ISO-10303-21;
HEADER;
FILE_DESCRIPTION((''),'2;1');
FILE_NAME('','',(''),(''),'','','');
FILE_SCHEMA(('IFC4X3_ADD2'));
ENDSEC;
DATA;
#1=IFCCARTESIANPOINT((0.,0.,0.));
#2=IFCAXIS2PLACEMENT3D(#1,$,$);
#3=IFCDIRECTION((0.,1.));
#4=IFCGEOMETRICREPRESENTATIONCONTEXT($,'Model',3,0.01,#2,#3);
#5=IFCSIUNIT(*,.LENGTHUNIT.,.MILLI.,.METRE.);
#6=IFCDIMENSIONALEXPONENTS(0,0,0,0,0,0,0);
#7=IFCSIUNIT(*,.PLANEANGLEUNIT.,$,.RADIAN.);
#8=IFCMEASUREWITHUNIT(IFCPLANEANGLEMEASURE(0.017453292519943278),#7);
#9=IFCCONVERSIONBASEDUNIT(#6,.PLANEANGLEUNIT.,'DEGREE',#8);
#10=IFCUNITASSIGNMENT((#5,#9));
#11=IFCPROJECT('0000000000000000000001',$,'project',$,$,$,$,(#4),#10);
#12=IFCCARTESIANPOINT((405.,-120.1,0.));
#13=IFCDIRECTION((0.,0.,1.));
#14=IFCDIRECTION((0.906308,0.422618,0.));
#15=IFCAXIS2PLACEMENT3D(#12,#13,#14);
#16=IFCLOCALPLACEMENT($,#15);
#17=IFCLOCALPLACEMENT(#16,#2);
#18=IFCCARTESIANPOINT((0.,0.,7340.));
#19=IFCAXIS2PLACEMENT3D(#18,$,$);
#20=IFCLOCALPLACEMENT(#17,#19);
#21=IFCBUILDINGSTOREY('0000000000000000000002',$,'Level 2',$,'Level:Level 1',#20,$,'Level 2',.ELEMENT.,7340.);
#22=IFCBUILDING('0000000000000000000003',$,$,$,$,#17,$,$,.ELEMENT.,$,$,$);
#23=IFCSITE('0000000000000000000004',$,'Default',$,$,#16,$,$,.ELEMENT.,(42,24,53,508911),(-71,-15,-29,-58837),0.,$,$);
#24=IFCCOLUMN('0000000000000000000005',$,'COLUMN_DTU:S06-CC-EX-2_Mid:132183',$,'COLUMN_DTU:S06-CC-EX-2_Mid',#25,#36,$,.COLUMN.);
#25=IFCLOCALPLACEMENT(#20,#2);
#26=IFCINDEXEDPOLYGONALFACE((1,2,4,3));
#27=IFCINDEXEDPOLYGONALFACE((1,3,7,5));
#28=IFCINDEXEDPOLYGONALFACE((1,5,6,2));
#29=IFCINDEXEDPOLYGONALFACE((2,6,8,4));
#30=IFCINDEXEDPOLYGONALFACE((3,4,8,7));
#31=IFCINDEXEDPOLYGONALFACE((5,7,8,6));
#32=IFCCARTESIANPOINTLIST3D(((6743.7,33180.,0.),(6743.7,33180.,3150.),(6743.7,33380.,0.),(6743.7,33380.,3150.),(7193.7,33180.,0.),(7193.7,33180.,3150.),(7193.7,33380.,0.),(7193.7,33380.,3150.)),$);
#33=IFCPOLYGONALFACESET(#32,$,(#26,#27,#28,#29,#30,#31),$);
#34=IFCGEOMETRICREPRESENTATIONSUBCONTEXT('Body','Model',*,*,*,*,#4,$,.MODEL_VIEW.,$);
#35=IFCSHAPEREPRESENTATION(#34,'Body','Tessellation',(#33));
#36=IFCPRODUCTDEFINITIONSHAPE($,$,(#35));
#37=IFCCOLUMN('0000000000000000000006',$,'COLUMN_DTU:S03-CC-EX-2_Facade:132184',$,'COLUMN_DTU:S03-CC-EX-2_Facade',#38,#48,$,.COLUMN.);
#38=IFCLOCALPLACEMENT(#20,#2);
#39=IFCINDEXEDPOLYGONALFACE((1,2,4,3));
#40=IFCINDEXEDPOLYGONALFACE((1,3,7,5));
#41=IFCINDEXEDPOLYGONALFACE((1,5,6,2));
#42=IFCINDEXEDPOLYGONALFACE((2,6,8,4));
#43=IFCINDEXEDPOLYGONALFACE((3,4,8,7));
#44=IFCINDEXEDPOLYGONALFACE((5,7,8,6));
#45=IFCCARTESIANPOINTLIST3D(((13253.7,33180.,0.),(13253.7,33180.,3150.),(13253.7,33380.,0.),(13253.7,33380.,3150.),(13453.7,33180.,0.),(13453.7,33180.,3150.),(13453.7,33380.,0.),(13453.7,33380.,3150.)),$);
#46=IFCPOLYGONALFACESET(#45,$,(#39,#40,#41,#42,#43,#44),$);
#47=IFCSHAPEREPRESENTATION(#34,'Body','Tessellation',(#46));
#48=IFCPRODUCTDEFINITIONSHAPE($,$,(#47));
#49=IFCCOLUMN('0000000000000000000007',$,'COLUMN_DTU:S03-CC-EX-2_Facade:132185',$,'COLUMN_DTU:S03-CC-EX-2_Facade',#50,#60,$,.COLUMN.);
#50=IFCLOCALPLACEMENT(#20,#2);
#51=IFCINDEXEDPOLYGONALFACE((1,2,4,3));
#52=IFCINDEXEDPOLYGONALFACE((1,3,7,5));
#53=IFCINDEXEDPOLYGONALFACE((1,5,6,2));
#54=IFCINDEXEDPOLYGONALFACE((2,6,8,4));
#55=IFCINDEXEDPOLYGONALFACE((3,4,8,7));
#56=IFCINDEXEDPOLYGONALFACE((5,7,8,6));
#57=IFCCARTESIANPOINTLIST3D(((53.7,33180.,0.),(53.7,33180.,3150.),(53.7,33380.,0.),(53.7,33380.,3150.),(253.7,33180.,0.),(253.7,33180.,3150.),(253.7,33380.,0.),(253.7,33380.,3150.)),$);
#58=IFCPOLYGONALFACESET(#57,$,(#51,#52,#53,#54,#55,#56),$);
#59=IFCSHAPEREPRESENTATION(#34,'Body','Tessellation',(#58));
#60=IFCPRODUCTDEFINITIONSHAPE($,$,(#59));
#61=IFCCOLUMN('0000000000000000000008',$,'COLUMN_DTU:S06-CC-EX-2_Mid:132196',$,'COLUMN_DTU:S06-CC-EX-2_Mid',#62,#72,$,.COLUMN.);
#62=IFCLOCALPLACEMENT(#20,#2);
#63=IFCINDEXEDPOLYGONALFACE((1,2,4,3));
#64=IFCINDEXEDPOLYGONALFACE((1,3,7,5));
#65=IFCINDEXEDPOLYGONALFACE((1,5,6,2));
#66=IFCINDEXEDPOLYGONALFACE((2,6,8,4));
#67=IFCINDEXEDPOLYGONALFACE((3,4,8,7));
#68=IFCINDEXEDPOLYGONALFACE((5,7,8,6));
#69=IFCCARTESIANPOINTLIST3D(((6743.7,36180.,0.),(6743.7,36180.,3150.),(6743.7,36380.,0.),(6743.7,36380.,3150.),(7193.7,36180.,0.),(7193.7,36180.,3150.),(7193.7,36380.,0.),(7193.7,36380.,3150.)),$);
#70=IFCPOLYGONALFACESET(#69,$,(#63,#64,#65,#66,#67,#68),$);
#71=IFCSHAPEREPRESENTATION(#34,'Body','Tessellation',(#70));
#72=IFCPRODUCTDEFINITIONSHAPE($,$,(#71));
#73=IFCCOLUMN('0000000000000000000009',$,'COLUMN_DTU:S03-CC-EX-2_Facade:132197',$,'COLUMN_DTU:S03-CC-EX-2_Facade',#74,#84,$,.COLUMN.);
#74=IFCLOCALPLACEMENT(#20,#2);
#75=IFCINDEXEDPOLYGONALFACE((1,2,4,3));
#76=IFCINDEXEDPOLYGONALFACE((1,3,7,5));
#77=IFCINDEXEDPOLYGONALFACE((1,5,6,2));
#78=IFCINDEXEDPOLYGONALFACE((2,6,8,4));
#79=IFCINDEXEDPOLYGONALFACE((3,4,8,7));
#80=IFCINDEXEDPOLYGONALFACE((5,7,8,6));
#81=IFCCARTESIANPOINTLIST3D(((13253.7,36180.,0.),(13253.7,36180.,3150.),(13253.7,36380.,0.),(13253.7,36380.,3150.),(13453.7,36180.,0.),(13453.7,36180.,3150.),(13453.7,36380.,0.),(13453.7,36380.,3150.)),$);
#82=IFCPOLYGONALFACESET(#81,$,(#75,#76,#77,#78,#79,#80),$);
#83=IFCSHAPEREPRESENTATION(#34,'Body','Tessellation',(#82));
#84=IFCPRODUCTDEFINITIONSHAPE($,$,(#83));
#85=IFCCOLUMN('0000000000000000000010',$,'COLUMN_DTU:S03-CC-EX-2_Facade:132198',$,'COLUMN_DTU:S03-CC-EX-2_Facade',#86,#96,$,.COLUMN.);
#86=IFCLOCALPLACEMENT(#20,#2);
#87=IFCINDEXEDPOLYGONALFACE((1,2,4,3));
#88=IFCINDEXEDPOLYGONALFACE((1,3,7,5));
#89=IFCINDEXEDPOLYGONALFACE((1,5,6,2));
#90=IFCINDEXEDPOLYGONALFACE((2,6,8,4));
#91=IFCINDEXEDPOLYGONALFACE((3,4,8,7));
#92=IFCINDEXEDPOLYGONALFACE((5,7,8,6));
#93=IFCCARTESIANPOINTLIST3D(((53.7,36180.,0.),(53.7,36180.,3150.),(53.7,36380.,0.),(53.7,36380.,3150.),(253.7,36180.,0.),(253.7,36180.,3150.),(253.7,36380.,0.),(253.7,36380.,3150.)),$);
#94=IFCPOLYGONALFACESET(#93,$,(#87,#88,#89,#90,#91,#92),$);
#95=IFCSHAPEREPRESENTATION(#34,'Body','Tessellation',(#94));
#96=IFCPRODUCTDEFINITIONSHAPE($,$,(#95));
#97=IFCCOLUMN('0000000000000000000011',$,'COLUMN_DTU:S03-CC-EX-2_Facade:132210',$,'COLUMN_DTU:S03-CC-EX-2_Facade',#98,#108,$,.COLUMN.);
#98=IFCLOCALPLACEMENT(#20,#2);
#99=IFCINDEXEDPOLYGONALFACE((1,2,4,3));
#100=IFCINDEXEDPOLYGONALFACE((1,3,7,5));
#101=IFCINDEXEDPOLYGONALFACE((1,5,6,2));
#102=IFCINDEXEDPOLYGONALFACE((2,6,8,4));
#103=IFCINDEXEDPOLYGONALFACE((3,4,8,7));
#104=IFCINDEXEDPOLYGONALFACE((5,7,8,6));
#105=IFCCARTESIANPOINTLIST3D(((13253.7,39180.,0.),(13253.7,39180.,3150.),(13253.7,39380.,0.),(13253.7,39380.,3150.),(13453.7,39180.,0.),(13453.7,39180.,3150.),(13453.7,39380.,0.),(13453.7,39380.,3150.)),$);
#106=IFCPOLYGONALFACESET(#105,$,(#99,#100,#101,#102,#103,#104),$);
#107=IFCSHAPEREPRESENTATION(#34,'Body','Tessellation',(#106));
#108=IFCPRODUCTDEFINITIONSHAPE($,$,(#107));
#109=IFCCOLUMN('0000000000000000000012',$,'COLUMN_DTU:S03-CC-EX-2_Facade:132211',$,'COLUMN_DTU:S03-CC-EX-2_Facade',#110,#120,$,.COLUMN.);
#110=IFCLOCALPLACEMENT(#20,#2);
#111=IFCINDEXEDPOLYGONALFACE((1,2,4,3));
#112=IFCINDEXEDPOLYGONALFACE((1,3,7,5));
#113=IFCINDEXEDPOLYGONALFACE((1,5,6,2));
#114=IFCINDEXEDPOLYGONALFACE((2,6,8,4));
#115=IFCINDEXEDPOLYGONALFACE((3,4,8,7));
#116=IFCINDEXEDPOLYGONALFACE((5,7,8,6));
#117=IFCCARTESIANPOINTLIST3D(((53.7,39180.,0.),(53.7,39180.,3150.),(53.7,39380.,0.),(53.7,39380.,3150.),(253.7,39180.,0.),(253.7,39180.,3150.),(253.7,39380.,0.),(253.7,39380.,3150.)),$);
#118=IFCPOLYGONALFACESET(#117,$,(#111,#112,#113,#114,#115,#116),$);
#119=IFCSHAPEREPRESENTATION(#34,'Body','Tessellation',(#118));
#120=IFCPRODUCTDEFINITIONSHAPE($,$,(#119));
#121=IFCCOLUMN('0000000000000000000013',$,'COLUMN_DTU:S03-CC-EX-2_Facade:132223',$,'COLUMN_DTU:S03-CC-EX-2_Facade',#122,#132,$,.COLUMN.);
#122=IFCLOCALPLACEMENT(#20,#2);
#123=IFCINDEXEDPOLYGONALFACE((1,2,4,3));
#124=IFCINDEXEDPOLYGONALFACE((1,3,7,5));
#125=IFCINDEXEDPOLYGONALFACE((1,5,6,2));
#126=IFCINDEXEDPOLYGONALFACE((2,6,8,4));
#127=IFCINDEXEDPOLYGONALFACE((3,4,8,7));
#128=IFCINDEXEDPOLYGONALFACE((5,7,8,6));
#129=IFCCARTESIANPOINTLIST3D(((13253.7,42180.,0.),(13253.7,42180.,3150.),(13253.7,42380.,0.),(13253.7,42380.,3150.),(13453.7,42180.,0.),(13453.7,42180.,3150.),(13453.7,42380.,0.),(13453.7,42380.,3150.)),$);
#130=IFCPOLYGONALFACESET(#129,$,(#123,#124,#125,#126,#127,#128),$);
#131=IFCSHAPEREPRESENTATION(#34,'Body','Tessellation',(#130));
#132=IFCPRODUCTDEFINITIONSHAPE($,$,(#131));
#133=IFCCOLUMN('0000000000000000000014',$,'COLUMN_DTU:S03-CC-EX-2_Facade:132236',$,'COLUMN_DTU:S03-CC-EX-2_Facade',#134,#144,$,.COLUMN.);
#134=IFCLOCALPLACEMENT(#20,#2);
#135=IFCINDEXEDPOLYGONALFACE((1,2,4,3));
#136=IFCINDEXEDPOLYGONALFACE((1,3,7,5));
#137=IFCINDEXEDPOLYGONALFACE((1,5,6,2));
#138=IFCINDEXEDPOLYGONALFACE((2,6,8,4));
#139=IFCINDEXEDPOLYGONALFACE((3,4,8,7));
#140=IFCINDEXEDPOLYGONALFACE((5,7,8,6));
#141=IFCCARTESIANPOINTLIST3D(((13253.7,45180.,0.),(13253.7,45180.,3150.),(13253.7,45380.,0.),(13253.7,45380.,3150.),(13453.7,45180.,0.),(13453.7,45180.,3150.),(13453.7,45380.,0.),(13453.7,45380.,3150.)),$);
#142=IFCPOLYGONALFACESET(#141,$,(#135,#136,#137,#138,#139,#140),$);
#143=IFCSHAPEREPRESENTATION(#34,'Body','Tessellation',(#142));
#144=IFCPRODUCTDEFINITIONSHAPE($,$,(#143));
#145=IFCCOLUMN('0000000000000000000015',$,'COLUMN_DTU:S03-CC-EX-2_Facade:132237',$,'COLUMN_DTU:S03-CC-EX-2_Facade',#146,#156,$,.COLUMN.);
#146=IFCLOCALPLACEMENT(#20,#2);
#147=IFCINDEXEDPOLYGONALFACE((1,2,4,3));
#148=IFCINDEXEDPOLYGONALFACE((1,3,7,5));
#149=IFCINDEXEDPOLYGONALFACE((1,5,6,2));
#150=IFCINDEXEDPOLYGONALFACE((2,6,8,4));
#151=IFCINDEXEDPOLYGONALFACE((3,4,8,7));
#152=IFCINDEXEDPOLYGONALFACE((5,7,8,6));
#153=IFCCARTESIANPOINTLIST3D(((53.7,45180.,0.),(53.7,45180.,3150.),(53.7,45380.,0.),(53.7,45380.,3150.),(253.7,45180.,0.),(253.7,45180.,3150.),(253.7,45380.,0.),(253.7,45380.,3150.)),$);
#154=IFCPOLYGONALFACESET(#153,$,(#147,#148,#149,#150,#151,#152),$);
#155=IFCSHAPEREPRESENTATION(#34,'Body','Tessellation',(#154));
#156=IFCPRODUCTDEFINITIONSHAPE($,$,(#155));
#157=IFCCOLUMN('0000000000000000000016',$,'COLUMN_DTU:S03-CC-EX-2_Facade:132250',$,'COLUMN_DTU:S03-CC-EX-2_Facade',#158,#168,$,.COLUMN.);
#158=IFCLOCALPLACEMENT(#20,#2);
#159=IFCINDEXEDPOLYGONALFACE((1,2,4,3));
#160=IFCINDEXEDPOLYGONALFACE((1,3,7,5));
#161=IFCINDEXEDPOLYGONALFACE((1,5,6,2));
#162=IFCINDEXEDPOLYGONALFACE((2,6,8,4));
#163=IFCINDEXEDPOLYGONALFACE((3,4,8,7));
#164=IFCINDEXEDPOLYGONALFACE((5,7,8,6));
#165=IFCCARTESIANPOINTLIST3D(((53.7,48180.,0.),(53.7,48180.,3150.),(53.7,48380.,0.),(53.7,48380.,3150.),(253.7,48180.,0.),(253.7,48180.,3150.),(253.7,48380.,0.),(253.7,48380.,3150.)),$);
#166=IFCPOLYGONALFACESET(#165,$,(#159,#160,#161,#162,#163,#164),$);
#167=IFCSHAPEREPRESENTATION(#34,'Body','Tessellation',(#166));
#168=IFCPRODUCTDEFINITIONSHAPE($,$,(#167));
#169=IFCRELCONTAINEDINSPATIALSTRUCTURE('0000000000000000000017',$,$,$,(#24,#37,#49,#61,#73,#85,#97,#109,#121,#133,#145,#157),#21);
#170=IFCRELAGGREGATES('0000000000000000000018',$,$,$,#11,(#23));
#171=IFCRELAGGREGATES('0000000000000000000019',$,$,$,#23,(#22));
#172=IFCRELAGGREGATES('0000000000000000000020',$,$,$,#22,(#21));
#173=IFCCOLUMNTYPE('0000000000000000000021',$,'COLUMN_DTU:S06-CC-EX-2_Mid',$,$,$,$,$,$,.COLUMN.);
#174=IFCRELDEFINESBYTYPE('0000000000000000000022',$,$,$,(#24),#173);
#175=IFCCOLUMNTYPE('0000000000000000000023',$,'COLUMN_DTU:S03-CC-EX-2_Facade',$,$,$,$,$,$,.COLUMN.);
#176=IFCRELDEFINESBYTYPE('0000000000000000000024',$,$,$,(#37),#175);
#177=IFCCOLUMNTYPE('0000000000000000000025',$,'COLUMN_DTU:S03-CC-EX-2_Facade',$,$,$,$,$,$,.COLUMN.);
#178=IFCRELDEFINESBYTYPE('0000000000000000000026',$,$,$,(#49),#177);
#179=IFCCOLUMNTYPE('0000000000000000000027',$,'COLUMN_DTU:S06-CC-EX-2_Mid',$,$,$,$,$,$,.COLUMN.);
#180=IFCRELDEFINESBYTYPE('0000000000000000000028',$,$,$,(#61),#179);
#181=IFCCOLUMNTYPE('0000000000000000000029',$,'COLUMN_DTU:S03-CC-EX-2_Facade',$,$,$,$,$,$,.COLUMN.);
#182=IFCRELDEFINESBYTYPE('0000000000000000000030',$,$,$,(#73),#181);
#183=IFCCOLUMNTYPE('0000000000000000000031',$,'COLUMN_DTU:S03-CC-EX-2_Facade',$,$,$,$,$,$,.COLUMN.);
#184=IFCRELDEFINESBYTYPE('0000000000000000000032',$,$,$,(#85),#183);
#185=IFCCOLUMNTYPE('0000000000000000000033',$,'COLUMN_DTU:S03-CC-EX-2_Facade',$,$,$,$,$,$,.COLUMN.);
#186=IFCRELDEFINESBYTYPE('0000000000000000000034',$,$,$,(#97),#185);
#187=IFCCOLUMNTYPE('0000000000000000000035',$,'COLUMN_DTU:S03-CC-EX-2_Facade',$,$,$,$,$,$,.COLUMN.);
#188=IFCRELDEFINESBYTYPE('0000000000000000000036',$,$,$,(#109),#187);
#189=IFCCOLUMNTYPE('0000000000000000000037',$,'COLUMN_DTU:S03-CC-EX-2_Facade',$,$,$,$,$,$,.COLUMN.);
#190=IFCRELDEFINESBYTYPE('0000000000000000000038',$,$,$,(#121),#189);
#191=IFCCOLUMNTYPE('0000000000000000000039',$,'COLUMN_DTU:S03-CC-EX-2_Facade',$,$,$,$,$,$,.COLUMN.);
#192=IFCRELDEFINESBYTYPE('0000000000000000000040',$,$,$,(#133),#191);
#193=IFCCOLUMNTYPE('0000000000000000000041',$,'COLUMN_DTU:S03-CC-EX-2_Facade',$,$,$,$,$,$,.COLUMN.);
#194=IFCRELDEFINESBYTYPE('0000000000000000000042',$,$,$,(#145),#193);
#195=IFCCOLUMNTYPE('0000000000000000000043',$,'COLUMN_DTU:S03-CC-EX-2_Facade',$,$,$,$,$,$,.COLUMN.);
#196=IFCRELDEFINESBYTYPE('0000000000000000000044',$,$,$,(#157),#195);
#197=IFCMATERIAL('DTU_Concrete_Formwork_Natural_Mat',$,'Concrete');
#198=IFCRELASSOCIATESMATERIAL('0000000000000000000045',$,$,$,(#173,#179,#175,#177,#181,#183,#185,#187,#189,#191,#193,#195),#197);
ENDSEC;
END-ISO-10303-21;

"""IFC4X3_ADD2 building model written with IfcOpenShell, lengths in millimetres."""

from ifc_helpers import new_model, entity, si_unit, converted_unit, direction, frame, frame_2d, origin, origin_2d_with_axis, place, context, subcontext, project, spatial, rectangle, extrude, source, transform, mapped, material, material_profile, profile_set, type_object, type_shapes, element, save


model = new_model("IFC4X3_ADD2")

# Units and contexts
model_context = context("Model", 3, precision=0.01, world=origin(), true_north=direction((0.0, 1.0)))
body_context = subcontext(model_context, "Body", "Model", "MODEL_VIEW")
ifc_project = project(units=[si_unit("LENGTHUNIT", "METRE", prefix="MILLI"), converted_unit("PLANEANGLEUNIT", "DEGREE", entity("IfcPlaneAngleMeasure", 0.017453292519943278), si_unit("PLANEANGLEUNIT", "RADIAN"), dimensions=[0, 0, 0, 0, 0, 0, 0])], contexts=[model_context])

# Site, building, storey
site_placement = place(None, frame((405.0, -120.1, 0.0), z_axis=(0.0, 0.0, 1.0), x_axis=(0.906308, 0.422618, 0.0)))
site = spatial("IfcSite", under=ifc_project, at=site_placement, Name="Default", CompositionType="ELEMENT", RefLatitude=(42, 24, 53, 508911), RefLongitude=(-71, -15, -29, -58837), RefElevation=0.0)
building_placement = place(site_placement, origin())
building = spatial("IfcBuilding", under=site, at=building_placement, CompositionType="ELEMENT")
storey_placement = place(building_placement, frame((0.0, 0.0, 7340.0)))
storey = spatial("IfcBuildingStorey", under=building, at=storey_placement, Name="Level 2", ObjectType="Level:Level 1", LongName="Level 2", CompositionType="ELEMENT", Elevation=7340.0)

# Columns
ifc_material = material(Name="DTU_Concrete_Formwork_Natural_Mat", Category="Concrete")
ifc_material_profile_1 = material_profile(ifc_material, rectangle(XDim=200.0, YDim=450.0, at=origin_2d_with_axis()), Name="S06-CC-EX-2_Mid")
ifc_profile_set_1 = profile_set([ifc_material_profile_1], Name="S06-CC-EX-2_Mid")
column_type_1 = type_object("IfcColumnType", Name="COLUMN_DTU:S06-CC-EX-2_Mid", PredefinedType="COLUMN", material=ifc_profile_set_1)
shared_shape_1 = source(origin(), body_context, "Body", "SweptSolid", [
    extrude(rectangle(XDim=200.0, YDim=450.0, at=origin_2d_with_axis()), frame((6968.7, 33280.0, 7340.0), z_axis=(0.0, 0.0, 1.0), x_axis=(0.0, 1.0, 0.0)), (0.0, 0.0, 1.0), 3150.0),
])
type_shapes(column_type_1, [shared_shape_1])
column_1_placement = place(storey_placement, frame((0.0, 0.0, -7340.0)))
element("IfcColumn", 1, at=column_1_placement, inside=storey, type_object=column_type_1, Name="COLUMN_DTU:S06-CC-EX-2_Mid:132183", ObjectType="COLUMN_DTU:S06-CC-EX-2_Mid", PredefinedType="COLUMN", context=body_context, shape_type="MappedRepresentation", body=[
    mapped(shared_shape_1, transform((0.0, 0.0, 0.0), scale=1.0)),
])
ifc_material_profile_2 = material_profile(ifc_material, rectangle(XDim=200.0, YDim=200.0, at=frame_2d((0.0, 0.0), x_axis=(1.0, 0.0))), Name="S03-CC-EX-2_Facade")
ifc_profile_set_2 = profile_set([ifc_material_profile_2], Name="S03-CC-EX-2_Facade")
column_type_2 = type_object("IfcColumnType", Name="COLUMN_DTU:S03-CC-EX-2_Facade", PredefinedType="COLUMN", material=ifc_profile_set_2)
shared_shape_2 = source(origin(), body_context, "Body", "SweptSolid", [
    extrude(rectangle(XDim=200.0, YDim=200.0, at=frame_2d((0.0, 0.0), x_axis=(1.0, 0.0))), frame((13353.7, 33280.0, 7340.0), z_axis=(0.0, 0.0, 1.0), x_axis=(0.0, -1.0, 0.0)), (0.0, 0.0, 1.0), 3150.0),
])
type_shapes(column_type_2, [shared_shape_2])
column_2_placement = place(storey_placement, frame((0.0, 0.0, -7340.0)))
element("IfcColumn", 2, at=column_2_placement, inside=storey, type_object=column_type_2, Name="COLUMN_DTU:S03-CC-EX-2_Facade:132184", ObjectType="COLUMN_DTU:S03-CC-EX-2_Facade", PredefinedType="COLUMN", context=body_context, shape_type="MappedRepresentation", body=[
    mapped(shared_shape_2, transform((0.0, 0.0, 0.0), scale=1.0)),
])
column_type_3 = type_object("IfcColumnType", Name="COLUMN_DTU:S03-CC-EX-2_Facade", PredefinedType="COLUMN", material=ifc_profile_set_2)
shared_shape_3 = source(origin(), body_context, "Body", "SweptSolid", [
    extrude(rectangle(XDim=200.0, YDim=200.0, at=frame_2d((0.0, 0.0), x_axis=(1.0, 0.0))), frame((153.7, 33280.0, 7340.0), z_axis=(0.0, 0.0, 1.0), x_axis=(0.0, -1.0, 0.0)), (0.0, 0.0, 1.0), 3150.0),
])
type_shapes(column_type_3, [shared_shape_3])
column_3_placement = place(storey_placement, frame((0.0, 0.0, -7340.0)))
element("IfcColumn", 3, at=column_3_placement, inside=storey, type_object=column_type_3, Name="COLUMN_DTU:S03-CC-EX-2_Facade:132185", ObjectType="COLUMN_DTU:S03-CC-EX-2_Facade", PredefinedType="COLUMN", context=body_context, shape_type="MappedRepresentation", body=[
    mapped(shared_shape_3, transform((0.0, 0.0, 0.0), scale=1.0)),
])
column_type_4 = type_object("IfcColumnType", Name="COLUMN_DTU:S06-CC-EX-2_Mid", PredefinedType="COLUMN", material=ifc_profile_set_1)
shared_shape_4 = source(origin(), body_context, "Body", "SweptSolid", [
    extrude(rectangle(XDim=200.0, YDim=450.0, at=origin_2d_with_axis()), frame((6968.7, 36280.0, 7340.0), z_axis=(0.0, 0.0, 1.0), x_axis=(0.0, 1.0, 0.0)), (0.0, 0.0, 1.0), 3150.0),
])
type_shapes(column_type_4, [shared_shape_4])
column_4_placement = place(storey_placement, frame((0.0, 0.0, -7340.0)))
element("IfcColumn", 4, at=column_4_placement, inside=storey, type_object=column_type_4, Name="COLUMN_DTU:S06-CC-EX-2_Mid:132196", ObjectType="COLUMN_DTU:S06-CC-EX-2_Mid", PredefinedType="COLUMN", context=body_context, shape_type="MappedRepresentation", body=[
    mapped(shared_shape_4, transform((0.0, 0.0, 0.0), scale=1.0)),
])
column_type_5 = type_object("IfcColumnType", Name="COLUMN_DTU:S03-CC-EX-2_Facade", PredefinedType="COLUMN", material=ifc_profile_set_2)
shared_shape_5 = source(origin(), body_context, "Body", "SweptSolid", [
    extrude(rectangle(XDim=200.0, YDim=200.0, at=frame_2d((0.0, 0.0), x_axis=(1.0, 0.0))), frame((13353.7, 36280.0, 7340.0), z_axis=(0.0, 0.0, 1.0), x_axis=(0.0, -1.0, 0.0)), (0.0, 0.0, 1.0), 3150.0),
])
type_shapes(column_type_5, [shared_shape_5])
column_5_placement = place(storey_placement, frame((0.0, 0.0, -7340.0)))
element("IfcColumn", 5, at=column_5_placement, inside=storey, type_object=column_type_5, Name="COLUMN_DTU:S03-CC-EX-2_Facade:132197", ObjectType="COLUMN_DTU:S03-CC-EX-2_Facade", PredefinedType="COLUMN", context=body_context, shape_type="MappedRepresentation", body=[
    mapped(shared_shape_5, transform((0.0, 0.0, 0.0), scale=1.0)),
])
column_type_6 = type_object("IfcColumnType", Name="COLUMN_DTU:S03-CC-EX-2_Facade", PredefinedType="COLUMN", material=ifc_profile_set_2)
shared_shape_6 = source(origin(), body_context, "Body", "SweptSolid", [
    extrude(rectangle(XDim=200.0, YDim=200.0, at=frame_2d((0.0, 0.0), x_axis=(1.0, 0.0))), frame((153.7, 36280.0, 7340.0), z_axis=(0.0, 0.0, 1.0), x_axis=(0.0, -1.0, 0.0)), (0.0, 0.0, 1.0), 3150.0),
])
type_shapes(column_type_6, [shared_shape_6])
column_6_placement = place(storey_placement, frame((0.0, 0.0, -7340.0)))
element("IfcColumn", 6, at=column_6_placement, inside=storey, type_object=column_type_6, Name="COLUMN_DTU:S03-CC-EX-2_Facade:132198", ObjectType="COLUMN_DTU:S03-CC-EX-2_Facade", PredefinedType="COLUMN", context=body_context, shape_type="MappedRepresentation", body=[
    mapped(shared_shape_6, transform((0.0, 0.0, 0.0), scale=1.0)),
])
column_type_7 = type_object("IfcColumnType", Name="COLUMN_DTU:S03-CC-EX-2_Facade", PredefinedType="COLUMN", material=ifc_profile_set_2)
shared_shape_7 = source(origin(), body_context, "Body", "SweptSolid", [
    extrude(rectangle(XDim=200.0, YDim=200.0, at=frame_2d((0.0, 0.0), x_axis=(1.0, 0.0))), frame((13353.7, 39280.0, 7340.0), z_axis=(0.0, 0.0, 1.0), x_axis=(0.0, -1.0, 0.0)), (0.0, 0.0, 1.0), 3150.0),
])
type_shapes(column_type_7, [shared_shape_7])
column_7_placement = place(storey_placement, frame((0.0, 0.0, -7340.0)))
element("IfcColumn", 7, at=column_7_placement, inside=storey, type_object=column_type_7, Name="COLUMN_DTU:S03-CC-EX-2_Facade:132210", ObjectType="COLUMN_DTU:S03-CC-EX-2_Facade", PredefinedType="COLUMN", context=body_context, shape_type="MappedRepresentation", body=[
    mapped(shared_shape_7, transform((0.0, 0.0, 0.0), scale=1.0)),
])
column_type_8 = type_object("IfcColumnType", Name="COLUMN_DTU:S03-CC-EX-2_Facade", PredefinedType="COLUMN", material=ifc_profile_set_2)
shared_shape_8 = source(origin(), body_context, "Body", "SweptSolid", [
    extrude(rectangle(XDim=200.0, YDim=200.0, at=frame_2d((0.0, 0.0), x_axis=(1.0, 0.0))), frame((153.7, 39280.0, 7340.0), z_axis=(0.0, 0.0, 1.0), x_axis=(0.0, -1.0, 0.0)), (0.0, 0.0, 1.0), 3150.0),
])
type_shapes(column_type_8, [shared_shape_8])
column_8_placement = place(storey_placement, frame((0.0, 0.0, -7340.0)))
element("IfcColumn", 8, at=column_8_placement, inside=storey, type_object=column_type_8, Name="COLUMN_DTU:S03-CC-EX-2_Facade:132211", ObjectType="COLUMN_DTU:S03-CC-EX-2_Facade", PredefinedType="COLUMN", context=body_context, shape_type="MappedRepresentation", body=[
    mapped(shared_shape_8, transform((0.0, 0.0, 0.0), scale=1.0)),
])
column_type_9 = type_object("IfcColumnType", Name="COLUMN_DTU:S03-CC-EX-2_Facade", PredefinedType="COLUMN", material=ifc_profile_set_2)
shared_shape_9 = source(origin(), body_context, "Body", "SweptSolid", [
    extrude(rectangle(XDim=200.0, YDim=200.0, at=frame_2d((0.0, 0.0), x_axis=(1.0, 0.0))), frame((13353.7, 42280.0, 7340.0), z_axis=(0.0, 0.0, 1.0), x_axis=(0.0, -1.0, 0.0)), (0.0, 0.0, 1.0), 3150.0),
])
type_shapes(column_type_9, [shared_shape_9])
column_9_placement = place(storey_placement, frame((0.0, 0.0, -7340.0)))
element("IfcColumn", 9, at=column_9_placement, inside=storey, type_object=column_type_9, Name="COLUMN_DTU:S03-CC-EX-2_Facade:132223", ObjectType="COLUMN_DTU:S03-CC-EX-2_Facade", PredefinedType="COLUMN", context=body_context, shape_type="MappedRepresentation", body=[
    mapped(shared_shape_9, transform((0.0, 0.0, 0.0), scale=1.0)),
])
column_type_10 = type_object("IfcColumnType", Name="COLUMN_DTU:S03-CC-EX-2_Facade", PredefinedType="COLUMN", material=ifc_profile_set_2)
shared_shape_10 = source(origin(), body_context, "Body", "SweptSolid", [
    extrude(rectangle(XDim=200.0, YDim=200.0, at=frame_2d((0.0, 0.0), x_axis=(1.0, 0.0))), frame((13353.7, 45280.0, 7340.0), z_axis=(0.0, 0.0, 1.0), x_axis=(0.0, -1.0, 0.0)), (0.0, 0.0, 1.0), 3150.0),
])
type_shapes(column_type_10, [shared_shape_10])
column_10_placement = place(storey_placement, frame((0.0, 0.0, -7340.0)))
element("IfcColumn", 10, at=column_10_placement, inside=storey, type_object=column_type_10, Name="COLUMN_DTU:S03-CC-EX-2_Facade:132236", ObjectType="COLUMN_DTU:S03-CC-EX-2_Facade", PredefinedType="COLUMN", context=body_context, shape_type="MappedRepresentation", body=[
    mapped(shared_shape_10, transform((0.0, 0.0, 0.0), scale=1.0)),
])
column_type_11 = type_object("IfcColumnType", Name="COLUMN_DTU:S03-CC-EX-2_Facade", PredefinedType="COLUMN", material=ifc_profile_set_2)
shared_shape_11 = source(origin(), body_context, "Body", "SweptSolid", [
    extrude(rectangle(XDim=200.0, YDim=200.0, at=frame_2d((0.0, 0.0), x_axis=(1.0, 0.0))), frame((153.7, 45280.0, 7340.0), z_axis=(0.0, 0.0, 1.0), x_axis=(0.0, -1.0, 0.0)), (0.0, 0.0, 1.0), 3150.0),
])
type_shapes(column_type_11, [shared_shape_11])
column_11_placement = place(storey_placement, frame((0.0, 0.0, -7340.0)))
element("IfcColumn", 11, at=column_11_placement, inside=storey, type_object=column_type_11, Name="COLUMN_DTU:S03-CC-EX-2_Facade:132237", ObjectType="COLUMN_DTU:S03-CC-EX-2_Facade", PredefinedType="COLUMN", context=body_context, shape_type="MappedRepresentation", body=[
    mapped(shared_shape_11, transform((0.0, 0.0, 0.0), scale=1.0)),
])
column_type_12 = type_object("IfcColumnType", Name="COLUMN_DTU:S03-CC-EX-2_Facade", PredefinedType="COLUMN", material=ifc_profile_set_2)
shared_shape_12 = source(origin(), body_context, "Body", "SweptSolid", [
    extrude(rectangle(XDim=200.0, YDim=200.0, at=frame_2d((0.0, 0.0), x_axis=(1.0, 0.0))), frame((153.7, 48280.0, 7340.0), z_axis=(0.0, 0.0, 1.0), x_axis=(0.0, -1.0, 0.0)), (0.0, 0.0, 1.0), 3150.0),
])
type_shapes(column_type_12, [shared_shape_12])
column_12_placement = place(storey_placement, frame((0.0, 0.0, -7340.0)))
element("IfcColumn", 12, at=column_12_placement, inside=storey, type_object=column_type_12, Name="COLUMN_DTU:S03-CC-EX-2_Facade:132250", ObjectType="COLUMN_DTU:S03-CC-EX-2_Facade", PredefinedType="COLUMN", context=body_context, shape_type="MappedRepresentation", body=[
    mapped(shared_shape_12, transform((0.0, 0.0, 0.0), scale=1.0)),
])

save(model, "model.ifc")
